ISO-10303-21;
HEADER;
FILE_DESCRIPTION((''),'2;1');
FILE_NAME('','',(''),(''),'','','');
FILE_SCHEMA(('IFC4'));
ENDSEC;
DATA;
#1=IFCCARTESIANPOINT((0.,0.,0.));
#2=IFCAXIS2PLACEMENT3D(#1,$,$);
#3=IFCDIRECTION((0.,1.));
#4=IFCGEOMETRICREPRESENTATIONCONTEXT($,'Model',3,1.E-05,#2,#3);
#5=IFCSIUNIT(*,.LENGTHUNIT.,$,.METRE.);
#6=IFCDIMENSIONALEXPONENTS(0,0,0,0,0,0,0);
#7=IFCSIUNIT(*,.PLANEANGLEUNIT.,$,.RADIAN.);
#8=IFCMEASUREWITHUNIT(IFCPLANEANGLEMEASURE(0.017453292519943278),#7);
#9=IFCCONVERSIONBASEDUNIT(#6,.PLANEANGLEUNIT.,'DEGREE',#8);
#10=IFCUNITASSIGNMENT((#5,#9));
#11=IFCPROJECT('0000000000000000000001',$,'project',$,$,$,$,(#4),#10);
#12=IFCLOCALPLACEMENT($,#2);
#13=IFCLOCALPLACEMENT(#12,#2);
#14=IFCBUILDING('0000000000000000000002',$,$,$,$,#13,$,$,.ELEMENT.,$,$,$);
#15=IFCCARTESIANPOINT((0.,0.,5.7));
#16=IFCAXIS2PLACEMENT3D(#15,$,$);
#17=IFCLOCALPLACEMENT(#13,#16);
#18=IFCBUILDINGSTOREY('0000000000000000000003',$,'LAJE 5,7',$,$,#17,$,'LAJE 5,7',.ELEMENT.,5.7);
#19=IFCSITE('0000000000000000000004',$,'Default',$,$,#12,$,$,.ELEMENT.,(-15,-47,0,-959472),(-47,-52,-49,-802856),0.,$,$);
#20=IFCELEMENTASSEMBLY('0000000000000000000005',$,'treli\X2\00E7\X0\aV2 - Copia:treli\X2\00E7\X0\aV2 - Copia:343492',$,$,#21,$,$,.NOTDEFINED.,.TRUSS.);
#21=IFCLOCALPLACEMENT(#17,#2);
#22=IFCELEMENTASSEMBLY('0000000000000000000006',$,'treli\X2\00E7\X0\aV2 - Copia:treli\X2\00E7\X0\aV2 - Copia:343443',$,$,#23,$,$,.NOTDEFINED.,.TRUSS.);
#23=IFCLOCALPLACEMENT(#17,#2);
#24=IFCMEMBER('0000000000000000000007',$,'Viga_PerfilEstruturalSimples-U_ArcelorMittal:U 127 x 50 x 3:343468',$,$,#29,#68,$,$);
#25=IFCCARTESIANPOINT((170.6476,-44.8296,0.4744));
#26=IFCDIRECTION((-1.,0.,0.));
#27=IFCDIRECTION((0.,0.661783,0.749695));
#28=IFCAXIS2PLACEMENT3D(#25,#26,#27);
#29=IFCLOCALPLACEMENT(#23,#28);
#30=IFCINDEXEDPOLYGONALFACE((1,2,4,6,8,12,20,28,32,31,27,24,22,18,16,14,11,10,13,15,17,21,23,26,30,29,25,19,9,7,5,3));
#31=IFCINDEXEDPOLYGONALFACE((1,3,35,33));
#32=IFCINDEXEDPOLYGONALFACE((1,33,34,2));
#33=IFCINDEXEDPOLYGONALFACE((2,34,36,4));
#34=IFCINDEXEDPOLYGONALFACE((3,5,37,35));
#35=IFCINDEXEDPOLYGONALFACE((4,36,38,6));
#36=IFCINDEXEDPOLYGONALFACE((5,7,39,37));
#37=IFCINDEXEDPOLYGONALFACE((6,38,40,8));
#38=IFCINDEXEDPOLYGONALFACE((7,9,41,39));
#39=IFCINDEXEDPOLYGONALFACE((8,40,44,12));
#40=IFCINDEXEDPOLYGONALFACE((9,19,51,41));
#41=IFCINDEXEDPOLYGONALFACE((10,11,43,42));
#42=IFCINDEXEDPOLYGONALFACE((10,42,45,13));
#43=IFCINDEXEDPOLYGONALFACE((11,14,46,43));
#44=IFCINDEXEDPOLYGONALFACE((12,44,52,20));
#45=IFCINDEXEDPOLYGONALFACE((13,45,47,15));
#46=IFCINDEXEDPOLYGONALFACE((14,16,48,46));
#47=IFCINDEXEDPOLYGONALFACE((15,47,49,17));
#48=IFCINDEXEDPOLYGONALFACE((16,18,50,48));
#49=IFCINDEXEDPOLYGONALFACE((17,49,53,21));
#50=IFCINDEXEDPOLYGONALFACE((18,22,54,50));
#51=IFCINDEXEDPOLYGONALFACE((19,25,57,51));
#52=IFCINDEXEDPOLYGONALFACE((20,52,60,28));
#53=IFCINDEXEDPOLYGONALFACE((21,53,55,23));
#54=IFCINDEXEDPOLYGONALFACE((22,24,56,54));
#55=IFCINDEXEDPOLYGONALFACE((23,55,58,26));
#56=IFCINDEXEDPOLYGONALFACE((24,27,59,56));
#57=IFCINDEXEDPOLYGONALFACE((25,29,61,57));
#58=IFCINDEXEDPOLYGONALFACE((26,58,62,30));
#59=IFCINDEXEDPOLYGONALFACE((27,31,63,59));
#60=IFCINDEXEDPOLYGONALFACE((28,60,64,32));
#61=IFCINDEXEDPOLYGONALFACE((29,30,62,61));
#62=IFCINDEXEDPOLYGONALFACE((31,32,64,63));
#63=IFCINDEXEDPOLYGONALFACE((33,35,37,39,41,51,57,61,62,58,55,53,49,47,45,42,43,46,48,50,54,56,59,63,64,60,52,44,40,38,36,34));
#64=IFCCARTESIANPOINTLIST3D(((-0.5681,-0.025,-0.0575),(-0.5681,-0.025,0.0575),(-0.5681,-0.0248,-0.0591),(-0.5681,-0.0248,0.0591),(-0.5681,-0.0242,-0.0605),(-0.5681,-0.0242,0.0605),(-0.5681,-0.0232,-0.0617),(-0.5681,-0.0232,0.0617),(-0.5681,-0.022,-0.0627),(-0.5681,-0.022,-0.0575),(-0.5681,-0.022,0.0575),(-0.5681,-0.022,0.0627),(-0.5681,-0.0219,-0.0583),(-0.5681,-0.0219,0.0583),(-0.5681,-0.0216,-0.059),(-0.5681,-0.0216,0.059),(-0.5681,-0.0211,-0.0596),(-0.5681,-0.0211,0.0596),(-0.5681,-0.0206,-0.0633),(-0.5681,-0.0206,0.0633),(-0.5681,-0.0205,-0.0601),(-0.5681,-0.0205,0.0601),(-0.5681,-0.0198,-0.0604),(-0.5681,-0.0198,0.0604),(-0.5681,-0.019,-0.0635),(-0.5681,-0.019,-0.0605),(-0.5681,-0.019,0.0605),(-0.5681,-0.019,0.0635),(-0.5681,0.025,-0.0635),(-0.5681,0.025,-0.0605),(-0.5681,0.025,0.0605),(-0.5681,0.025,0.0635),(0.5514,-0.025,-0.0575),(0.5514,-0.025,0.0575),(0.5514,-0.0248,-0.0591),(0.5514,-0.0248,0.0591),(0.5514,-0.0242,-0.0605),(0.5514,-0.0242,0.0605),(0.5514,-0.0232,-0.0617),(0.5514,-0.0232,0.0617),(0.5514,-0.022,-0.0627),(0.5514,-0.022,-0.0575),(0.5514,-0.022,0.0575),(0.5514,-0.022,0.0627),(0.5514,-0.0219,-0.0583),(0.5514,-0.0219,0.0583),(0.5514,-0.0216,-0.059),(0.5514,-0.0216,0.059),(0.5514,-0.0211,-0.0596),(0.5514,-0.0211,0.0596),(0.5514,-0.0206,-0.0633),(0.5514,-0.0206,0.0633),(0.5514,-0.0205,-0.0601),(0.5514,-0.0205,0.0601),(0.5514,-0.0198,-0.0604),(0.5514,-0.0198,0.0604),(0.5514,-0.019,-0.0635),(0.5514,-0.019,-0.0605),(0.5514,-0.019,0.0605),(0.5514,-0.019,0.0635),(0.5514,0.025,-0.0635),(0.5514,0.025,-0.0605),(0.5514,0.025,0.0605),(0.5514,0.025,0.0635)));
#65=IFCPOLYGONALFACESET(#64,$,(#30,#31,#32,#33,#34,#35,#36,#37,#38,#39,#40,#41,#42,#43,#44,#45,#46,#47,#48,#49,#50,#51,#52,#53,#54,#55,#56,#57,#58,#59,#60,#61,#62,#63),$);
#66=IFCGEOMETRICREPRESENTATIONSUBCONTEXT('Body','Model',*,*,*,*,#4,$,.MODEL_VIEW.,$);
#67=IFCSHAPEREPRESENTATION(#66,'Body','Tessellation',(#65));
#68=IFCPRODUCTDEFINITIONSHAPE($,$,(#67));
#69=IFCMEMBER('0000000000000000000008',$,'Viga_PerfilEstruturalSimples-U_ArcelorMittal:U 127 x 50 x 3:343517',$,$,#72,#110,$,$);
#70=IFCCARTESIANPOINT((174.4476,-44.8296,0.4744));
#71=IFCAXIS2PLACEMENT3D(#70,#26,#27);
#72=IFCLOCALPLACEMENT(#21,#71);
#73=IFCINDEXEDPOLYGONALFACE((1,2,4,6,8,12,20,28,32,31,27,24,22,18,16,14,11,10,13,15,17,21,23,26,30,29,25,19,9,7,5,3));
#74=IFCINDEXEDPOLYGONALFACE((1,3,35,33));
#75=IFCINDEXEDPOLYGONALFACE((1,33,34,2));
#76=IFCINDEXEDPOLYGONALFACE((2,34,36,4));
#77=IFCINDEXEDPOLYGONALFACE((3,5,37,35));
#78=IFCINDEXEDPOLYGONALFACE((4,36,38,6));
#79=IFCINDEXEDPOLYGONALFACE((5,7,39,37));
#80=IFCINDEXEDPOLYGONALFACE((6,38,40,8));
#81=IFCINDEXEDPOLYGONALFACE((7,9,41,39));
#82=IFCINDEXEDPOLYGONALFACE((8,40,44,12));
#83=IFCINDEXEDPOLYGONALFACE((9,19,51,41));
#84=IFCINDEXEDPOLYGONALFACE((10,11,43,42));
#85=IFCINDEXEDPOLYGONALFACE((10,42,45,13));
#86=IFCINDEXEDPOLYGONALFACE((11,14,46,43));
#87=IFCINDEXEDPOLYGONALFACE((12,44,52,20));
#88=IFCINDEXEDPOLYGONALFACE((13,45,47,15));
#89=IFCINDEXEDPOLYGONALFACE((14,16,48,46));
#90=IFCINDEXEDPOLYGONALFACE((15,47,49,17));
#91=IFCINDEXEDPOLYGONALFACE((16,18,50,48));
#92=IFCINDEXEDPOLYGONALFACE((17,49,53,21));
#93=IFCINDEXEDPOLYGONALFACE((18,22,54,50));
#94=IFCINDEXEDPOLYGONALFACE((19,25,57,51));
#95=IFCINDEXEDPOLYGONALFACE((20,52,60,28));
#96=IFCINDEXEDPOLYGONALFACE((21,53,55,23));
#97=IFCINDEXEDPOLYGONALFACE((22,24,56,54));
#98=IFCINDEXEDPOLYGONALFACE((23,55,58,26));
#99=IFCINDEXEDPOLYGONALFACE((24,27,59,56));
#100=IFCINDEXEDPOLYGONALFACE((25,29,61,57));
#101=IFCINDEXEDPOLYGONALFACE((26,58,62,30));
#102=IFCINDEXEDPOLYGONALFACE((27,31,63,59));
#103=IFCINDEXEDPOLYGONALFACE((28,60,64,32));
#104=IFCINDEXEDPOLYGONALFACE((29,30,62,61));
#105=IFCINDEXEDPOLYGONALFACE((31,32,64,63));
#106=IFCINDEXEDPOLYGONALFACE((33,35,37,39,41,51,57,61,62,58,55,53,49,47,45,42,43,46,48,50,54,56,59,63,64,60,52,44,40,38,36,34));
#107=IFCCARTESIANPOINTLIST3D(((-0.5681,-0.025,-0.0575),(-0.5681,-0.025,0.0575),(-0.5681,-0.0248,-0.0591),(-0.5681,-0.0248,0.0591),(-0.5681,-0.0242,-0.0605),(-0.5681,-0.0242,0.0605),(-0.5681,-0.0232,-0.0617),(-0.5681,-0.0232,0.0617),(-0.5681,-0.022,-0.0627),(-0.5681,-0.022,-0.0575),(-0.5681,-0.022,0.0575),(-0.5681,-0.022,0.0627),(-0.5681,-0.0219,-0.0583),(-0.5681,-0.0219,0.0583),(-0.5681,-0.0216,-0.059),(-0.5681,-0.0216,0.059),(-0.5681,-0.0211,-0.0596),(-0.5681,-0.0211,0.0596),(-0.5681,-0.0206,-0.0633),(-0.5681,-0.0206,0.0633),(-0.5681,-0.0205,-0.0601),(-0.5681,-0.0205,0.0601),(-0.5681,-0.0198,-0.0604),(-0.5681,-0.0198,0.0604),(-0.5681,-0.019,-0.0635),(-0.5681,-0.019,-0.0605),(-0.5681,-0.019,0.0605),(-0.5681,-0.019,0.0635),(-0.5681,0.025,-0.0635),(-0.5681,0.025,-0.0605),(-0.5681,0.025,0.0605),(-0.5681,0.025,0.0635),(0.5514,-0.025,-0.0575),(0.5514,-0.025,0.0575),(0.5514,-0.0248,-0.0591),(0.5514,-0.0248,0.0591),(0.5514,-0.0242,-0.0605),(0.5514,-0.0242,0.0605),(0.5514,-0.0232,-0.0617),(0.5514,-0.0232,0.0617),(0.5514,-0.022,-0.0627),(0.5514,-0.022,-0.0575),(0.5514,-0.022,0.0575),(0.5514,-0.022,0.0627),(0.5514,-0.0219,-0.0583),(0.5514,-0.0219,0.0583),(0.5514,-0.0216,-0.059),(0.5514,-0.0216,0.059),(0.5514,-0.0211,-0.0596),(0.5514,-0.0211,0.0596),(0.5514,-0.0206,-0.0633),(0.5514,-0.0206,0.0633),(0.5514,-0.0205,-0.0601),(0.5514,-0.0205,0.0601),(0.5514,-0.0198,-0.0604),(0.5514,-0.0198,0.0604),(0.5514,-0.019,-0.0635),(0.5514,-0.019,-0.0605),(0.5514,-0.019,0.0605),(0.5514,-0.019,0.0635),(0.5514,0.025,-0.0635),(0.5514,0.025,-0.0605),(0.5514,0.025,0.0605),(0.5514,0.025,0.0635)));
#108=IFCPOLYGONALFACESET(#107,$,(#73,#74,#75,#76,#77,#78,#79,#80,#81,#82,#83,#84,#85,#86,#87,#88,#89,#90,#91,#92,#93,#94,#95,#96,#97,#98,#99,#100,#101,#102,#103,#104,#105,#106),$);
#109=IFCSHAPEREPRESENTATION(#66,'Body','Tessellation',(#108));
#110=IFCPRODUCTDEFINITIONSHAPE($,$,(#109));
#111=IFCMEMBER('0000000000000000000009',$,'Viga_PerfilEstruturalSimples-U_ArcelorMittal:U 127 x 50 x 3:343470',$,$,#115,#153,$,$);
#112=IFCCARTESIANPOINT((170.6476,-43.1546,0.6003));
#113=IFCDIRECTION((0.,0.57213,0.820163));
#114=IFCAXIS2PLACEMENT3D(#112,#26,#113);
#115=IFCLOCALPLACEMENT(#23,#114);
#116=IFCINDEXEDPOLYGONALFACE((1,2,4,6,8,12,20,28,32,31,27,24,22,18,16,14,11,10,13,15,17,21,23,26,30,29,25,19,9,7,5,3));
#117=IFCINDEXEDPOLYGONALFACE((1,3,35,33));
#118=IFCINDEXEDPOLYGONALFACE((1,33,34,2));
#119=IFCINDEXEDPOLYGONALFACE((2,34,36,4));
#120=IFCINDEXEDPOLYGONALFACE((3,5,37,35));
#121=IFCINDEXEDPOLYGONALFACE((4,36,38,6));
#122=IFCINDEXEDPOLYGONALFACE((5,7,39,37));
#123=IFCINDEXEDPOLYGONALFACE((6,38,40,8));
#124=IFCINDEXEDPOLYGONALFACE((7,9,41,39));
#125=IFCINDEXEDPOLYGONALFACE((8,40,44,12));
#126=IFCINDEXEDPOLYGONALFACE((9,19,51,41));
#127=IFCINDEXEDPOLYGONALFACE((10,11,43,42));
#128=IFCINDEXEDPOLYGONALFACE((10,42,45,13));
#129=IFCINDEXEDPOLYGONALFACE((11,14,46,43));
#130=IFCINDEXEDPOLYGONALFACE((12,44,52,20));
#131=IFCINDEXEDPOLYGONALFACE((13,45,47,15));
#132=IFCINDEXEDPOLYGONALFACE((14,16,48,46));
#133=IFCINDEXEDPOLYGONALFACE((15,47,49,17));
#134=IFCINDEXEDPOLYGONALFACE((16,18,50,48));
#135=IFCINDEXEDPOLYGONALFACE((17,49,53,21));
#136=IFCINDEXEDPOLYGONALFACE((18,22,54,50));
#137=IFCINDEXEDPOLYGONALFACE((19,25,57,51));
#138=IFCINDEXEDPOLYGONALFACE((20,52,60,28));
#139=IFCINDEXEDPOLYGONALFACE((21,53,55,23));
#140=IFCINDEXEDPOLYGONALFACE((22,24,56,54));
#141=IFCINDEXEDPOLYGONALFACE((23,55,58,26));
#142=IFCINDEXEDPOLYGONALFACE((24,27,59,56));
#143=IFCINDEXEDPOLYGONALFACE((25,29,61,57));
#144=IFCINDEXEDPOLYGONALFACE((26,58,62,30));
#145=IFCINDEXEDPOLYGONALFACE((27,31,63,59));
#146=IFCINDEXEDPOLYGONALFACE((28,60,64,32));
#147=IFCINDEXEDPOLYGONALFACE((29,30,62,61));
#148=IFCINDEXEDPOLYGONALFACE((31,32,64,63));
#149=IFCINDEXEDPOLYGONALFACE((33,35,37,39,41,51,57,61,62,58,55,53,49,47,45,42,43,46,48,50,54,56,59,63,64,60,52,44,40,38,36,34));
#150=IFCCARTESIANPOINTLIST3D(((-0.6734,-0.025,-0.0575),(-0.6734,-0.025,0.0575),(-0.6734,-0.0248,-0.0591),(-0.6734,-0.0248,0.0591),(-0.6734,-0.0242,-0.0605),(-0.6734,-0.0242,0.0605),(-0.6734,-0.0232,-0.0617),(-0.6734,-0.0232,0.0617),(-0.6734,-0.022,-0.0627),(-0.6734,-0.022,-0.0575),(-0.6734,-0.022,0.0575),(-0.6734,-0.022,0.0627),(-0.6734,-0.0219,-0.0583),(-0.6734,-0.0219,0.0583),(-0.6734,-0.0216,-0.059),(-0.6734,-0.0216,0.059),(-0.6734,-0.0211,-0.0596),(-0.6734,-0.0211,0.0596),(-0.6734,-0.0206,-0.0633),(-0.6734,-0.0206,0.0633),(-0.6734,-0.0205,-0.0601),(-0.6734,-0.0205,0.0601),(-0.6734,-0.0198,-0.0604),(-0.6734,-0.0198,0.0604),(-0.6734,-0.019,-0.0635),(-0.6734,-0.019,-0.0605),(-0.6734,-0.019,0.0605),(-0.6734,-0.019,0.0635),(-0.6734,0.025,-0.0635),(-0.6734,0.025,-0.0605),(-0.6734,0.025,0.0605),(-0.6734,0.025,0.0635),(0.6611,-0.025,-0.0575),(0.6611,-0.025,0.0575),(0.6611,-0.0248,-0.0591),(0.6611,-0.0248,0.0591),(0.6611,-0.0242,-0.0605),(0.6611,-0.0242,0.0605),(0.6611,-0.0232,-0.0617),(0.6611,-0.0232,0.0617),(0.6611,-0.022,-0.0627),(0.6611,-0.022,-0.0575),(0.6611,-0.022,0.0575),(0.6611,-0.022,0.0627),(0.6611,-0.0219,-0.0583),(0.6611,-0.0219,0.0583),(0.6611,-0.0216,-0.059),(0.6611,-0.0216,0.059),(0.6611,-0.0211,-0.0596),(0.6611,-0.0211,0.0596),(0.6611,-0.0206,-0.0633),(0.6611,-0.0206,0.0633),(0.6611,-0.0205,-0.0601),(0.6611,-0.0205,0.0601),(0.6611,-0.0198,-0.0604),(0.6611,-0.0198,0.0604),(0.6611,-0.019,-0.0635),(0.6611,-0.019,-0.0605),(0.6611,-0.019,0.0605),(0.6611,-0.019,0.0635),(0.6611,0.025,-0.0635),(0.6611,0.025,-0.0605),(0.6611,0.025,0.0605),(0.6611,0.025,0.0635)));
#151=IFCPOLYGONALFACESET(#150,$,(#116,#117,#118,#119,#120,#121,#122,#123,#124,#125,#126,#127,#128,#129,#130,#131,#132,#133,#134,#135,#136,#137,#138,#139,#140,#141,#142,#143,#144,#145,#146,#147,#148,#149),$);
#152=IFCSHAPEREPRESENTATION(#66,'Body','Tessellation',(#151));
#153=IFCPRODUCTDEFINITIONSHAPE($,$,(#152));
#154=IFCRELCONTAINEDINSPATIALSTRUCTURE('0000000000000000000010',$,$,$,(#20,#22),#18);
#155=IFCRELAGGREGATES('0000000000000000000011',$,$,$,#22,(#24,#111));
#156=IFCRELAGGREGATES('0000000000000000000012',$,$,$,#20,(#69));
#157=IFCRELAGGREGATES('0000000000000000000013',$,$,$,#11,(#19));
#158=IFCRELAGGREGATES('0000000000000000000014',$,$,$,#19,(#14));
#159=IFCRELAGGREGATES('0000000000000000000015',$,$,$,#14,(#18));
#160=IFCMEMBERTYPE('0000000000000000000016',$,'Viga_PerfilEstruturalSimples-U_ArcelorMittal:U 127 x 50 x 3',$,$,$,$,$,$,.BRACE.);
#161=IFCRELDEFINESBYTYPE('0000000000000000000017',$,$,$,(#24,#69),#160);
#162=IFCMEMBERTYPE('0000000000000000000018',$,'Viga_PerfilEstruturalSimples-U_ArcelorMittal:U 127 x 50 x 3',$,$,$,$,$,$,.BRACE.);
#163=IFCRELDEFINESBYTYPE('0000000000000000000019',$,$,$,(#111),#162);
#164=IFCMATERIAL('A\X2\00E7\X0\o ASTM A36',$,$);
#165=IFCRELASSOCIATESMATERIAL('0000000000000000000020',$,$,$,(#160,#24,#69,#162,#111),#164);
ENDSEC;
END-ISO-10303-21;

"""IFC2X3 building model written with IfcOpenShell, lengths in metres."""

from ifc_helpers import new_model, entity, si_unit, converted_unit, direction, frame, frame_2d, origin, place, context, subcontext, project, spatial, polyline, circle_curve, parameter, trimmed, segment, composite_curve, outline, extrude, source, transform, mapped, material, type_object, type_shapes, element, aggregate, save


model = new_model("IFC2X3")

# Units and contexts
model_context = context("Model", 3, precision=1e-05, world=origin(), true_north=direction((0.0, 1.0)))
body_context = subcontext(model_context, "Body", "Model", "MODEL_VIEW")
ifc_project = project(units=[si_unit("LENGTHUNIT", "METRE"), converted_unit("PLANEANGLEUNIT", "DEGREE", entity("IfcPlaneAngleMeasure", 0.017453292519943278), si_unit("PLANEANGLEUNIT", "RADIAN"), dimensions=[0, 0, 0, 0, 0, 0, 0])], contexts=[model_context])

# Site, building, storey
site_placement = place(None, origin())
site = spatial("IfcSite", under=ifc_project, at=site_placement, Name="Default", CompositionType="ELEMENT", RefLatitude=(-15, -47, 0, -959472), RefLongitude=(-47, -52, -49, -802856), RefElevation=0.0)
building_placement = place(site_placement, origin())
building = spatial("IfcBuilding", under=site, at=building_placement, CompositionType="ELEMENT")
storey_placement = place(building_placement, frame((0.0, 0.0, 5.7)))
storey = spatial("IfcBuildingStorey", under=building, at=storey_placement, Name="LAJE 5,7", LongName="LAJE 5,7", CompositionType="ELEMENT", Elevation=5.7)

# Element assembly
assembly_1_placement = place(storey_placement, origin())
assembly_1 = element("IfcElementAssembly", 1, at=assembly_1_placement, inside=storey, Name="treliçaV2 - Copia:treliçaV2 - Copia:343492", AssemblyPlace="NOTDEFINED", PredefinedType="TRUSS")
ifc_material = material(Name="Aço ASTM A36")

# Element assembly
assembly_2_placement = place(storey_placement, origin())
assembly_2 = element("IfcElementAssembly", 2, at=assembly_2_placement, inside=storey, Name="treliçaV2 - Copia:treliçaV2 - Copia:343443", AssemblyPlace="NOTDEFINED", PredefinedType="TRUSS")

# Members
member_type_1 = type_object("IfcMemberType", Name="Viga_PerfilEstruturalSimples-U_ArcelorMittal:U 127 x 50 x 3", PredefinedType="BRACE", material=ifc_material)
shared_shape_1 = source(origin(), body_context, "Body", "SweptSolid", [
    extrude(outline(composite_curve([segment(polyline([(-0.0575, -0.0192), (0.0575, -0.0192)]), True, "CONTINUOUS"), segment(trimmed(circle_curve(frame_2d((0.0575, -0.0132), x_axis=(0.0, 1.0)), 0.006), [parameter(180.0)], [parameter(270.0)], True, "PARAMETER"), True, "CONTINUOUS"), segment(polyline([(0.0635, -0.0132), (0.0635, 0.0308)]), True, "CONTINUOUS"), segment(polyline([(0.0635, 0.0308), (0.0605, 0.0308)]), True, "CONTINUOUS"), segment(polyline([(0.0605, 0.0308), (0.0605, -0.0132)]), True, "CONTINUOUS"), segment(trimmed(circle_curve(frame_2d((0.0575, -0.0132), x_axis=(0.0, 1.0)), 0.003), [parameter(180.0)], [parameter(270.0)], True, "PARAMETER"), False, "CONTINUOUS"), segment(polyline([(0.0575, -0.0162), (-0.0575, -0.0162)]), True, "CONTINUOUS"), segment(trimmed(circle_curve(frame_2d((-0.0575, -0.0132), x_axis=(0.0, 1.0)), 0.003), [parameter(90.0)], [parameter(180.0)], True, "PARAMETER"), False, "CONTINUOUS"), segment(polyline([(-0.0605, -0.0132), (-0.0605, 0.0308)]), True, "CONTINUOUS"), segment(polyline([(-0.0605, 0.0308), (-0.0635, 0.0308)]), True, "CONTINUOUS"), segment(polyline([(-0.0635, 0.0308), (-0.0635, -0.0132)]), True, "CONTINUOUS"), segment(trimmed(circle_curve(frame_2d((-0.0575, -0.0132), x_axis=(0.0, 1.0)), 0.006), [parameter(90.0)], [parameter(180.0)], True, "PARAMETER"), True, "CONTINUOUS")], self_intersect=False)), frame((-0.5681, -0.0058, 0.0), z_axis=(1.0, 0.0, 0.0), x_axis=(0.0, 0.0, -1.0)), (0.0, 0.0, 1.0), 1.1195),
])
type_shapes(member_type_1, [shared_shape_1])
member_1_placement = place(assembly_2_placement, frame((170.6476, -44.8296, 0.4744), z_axis=(-1.0, 0.0, 0.0), x_axis=(0.0, 0.661783, 0.749695)))
member_1 = element("IfcMember", 3, at=member_1_placement, type_object=member_type_1, material=ifc_material, Name="Viga_PerfilEstruturalSimples-U_ArcelorMittal:U 127 x 50 x 3:343468", context=body_context, shape_type="MappedRepresentation", body=[
    mapped(shared_shape_1, transform((0.0, 0.0, 0.0), scale=1.0)),
])
member_2_placement = place(assembly_1_placement, frame((174.4476, -44.8296, 0.4744), z_axis=(-1.0, 0.0, 0.0), x_axis=(0.0, 0.661783, 0.749695)))
member_2 = element("IfcMember", 4, at=member_2_placement, type_object=member_type_1, material=ifc_material, Name="Viga_PerfilEstruturalSimples-U_ArcelorMittal:U 127 x 50 x 3:343517", context=body_context, shape_type="MappedRepresentation", body=[
    mapped(shared_shape_1, transform((0.0, 0.0, 0.0), scale=1.0)),
])
member_type_2 = type_object("IfcMemberType", Name="Viga_PerfilEstruturalSimples-U_ArcelorMittal:U 127 x 50 x 3", PredefinedType="BRACE", material=ifc_material)
shared_shape_2 = source(origin(), body_context, "Body", "SweptSolid", [
    extrude(outline(composite_curve([segment(polyline([(-0.0575, -0.0192), (0.0575, -0.0192)]), True, "CONTINUOUS"), segment(trimmed(circle_curve(frame_2d((0.0575, -0.0132), x_axis=(0.0, 1.0)), 0.006), [parameter(180.0)], [parameter(270.0)], True, "PARAMETER"), True, "CONTINUOUS"), segment(polyline([(0.0635, -0.0132), (0.0635, 0.0308)]), True, "CONTINUOUS"), segment(polyline([(0.0635, 0.0308), (0.0605, 0.0308)]), True, "CONTINUOUS"), segment(polyline([(0.0605, 0.0308), (0.0605, -0.0132)]), True, "CONTINUOUS"), segment(trimmed(circle_curve(frame_2d((0.0575, -0.0132), x_axis=(0.0, 1.0)), 0.003), [parameter(180.0)], [parameter(270.0)], True, "PARAMETER"), False, "CONTINUOUS"), segment(polyline([(0.0575, -0.0162), (-0.0575, -0.0162)]), True, "CONTINUOUS"), segment(trimmed(circle_curve(frame_2d((-0.0575, -0.0132), x_axis=(0.0, 1.0)), 0.003), [parameter(90.0)], [parameter(180.0)], True, "PARAMETER"), False, "CONTINUOUS"), segment(polyline([(-0.0605, -0.0132), (-0.0605, 0.0308)]), True, "CONTINUOUS"), segment(polyline([(-0.0605, 0.0308), (-0.0635, 0.0308)]), True, "CONTINUOUS"), segment(polyline([(-0.0635, 0.0308), (-0.0635, -0.0132)]), True, "CONTINUOUS"), segment(trimmed(circle_curve(frame_2d((-0.0575, -0.0132), x_axis=(0.0, 1.0)), 0.006), [parameter(90.0)], [parameter(180.0)], True, "PARAMETER"), True, "CONTINUOUS")], self_intersect=False)), frame((-0.6734, -0.0058, 0.0), z_axis=(1.0, 0.0, 0.0), x_axis=(0.0, 0.0, -1.0)), (0.0, 0.0, 1.0), 1.3345),
])
type_shapes(member_type_2, [shared_shape_2])
member_3_placement = place(assembly_2_placement, frame((170.6476, -43.1546, 0.6003), z_axis=(-1.0, 0.0, 0.0), x_axis=(0.0, 0.57213, 0.820163)))
member_3 = element("IfcMember", 5, at=member_3_placement, type_object=member_type_2, material=ifc_material, Name="Viga_PerfilEstruturalSimples-U_ArcelorMittal:U 127 x 50 x 3:343470", context=body_context, shape_type="MappedRepresentation", body=[
    mapped(shared_shape_2, transform((0.0, 0.0, 0.0), scale=1.0)),
])
aggregate(assembly_2, [member_1, member_3])
aggregate(assembly_1, [member_2])

save(model, "model.ifc")
